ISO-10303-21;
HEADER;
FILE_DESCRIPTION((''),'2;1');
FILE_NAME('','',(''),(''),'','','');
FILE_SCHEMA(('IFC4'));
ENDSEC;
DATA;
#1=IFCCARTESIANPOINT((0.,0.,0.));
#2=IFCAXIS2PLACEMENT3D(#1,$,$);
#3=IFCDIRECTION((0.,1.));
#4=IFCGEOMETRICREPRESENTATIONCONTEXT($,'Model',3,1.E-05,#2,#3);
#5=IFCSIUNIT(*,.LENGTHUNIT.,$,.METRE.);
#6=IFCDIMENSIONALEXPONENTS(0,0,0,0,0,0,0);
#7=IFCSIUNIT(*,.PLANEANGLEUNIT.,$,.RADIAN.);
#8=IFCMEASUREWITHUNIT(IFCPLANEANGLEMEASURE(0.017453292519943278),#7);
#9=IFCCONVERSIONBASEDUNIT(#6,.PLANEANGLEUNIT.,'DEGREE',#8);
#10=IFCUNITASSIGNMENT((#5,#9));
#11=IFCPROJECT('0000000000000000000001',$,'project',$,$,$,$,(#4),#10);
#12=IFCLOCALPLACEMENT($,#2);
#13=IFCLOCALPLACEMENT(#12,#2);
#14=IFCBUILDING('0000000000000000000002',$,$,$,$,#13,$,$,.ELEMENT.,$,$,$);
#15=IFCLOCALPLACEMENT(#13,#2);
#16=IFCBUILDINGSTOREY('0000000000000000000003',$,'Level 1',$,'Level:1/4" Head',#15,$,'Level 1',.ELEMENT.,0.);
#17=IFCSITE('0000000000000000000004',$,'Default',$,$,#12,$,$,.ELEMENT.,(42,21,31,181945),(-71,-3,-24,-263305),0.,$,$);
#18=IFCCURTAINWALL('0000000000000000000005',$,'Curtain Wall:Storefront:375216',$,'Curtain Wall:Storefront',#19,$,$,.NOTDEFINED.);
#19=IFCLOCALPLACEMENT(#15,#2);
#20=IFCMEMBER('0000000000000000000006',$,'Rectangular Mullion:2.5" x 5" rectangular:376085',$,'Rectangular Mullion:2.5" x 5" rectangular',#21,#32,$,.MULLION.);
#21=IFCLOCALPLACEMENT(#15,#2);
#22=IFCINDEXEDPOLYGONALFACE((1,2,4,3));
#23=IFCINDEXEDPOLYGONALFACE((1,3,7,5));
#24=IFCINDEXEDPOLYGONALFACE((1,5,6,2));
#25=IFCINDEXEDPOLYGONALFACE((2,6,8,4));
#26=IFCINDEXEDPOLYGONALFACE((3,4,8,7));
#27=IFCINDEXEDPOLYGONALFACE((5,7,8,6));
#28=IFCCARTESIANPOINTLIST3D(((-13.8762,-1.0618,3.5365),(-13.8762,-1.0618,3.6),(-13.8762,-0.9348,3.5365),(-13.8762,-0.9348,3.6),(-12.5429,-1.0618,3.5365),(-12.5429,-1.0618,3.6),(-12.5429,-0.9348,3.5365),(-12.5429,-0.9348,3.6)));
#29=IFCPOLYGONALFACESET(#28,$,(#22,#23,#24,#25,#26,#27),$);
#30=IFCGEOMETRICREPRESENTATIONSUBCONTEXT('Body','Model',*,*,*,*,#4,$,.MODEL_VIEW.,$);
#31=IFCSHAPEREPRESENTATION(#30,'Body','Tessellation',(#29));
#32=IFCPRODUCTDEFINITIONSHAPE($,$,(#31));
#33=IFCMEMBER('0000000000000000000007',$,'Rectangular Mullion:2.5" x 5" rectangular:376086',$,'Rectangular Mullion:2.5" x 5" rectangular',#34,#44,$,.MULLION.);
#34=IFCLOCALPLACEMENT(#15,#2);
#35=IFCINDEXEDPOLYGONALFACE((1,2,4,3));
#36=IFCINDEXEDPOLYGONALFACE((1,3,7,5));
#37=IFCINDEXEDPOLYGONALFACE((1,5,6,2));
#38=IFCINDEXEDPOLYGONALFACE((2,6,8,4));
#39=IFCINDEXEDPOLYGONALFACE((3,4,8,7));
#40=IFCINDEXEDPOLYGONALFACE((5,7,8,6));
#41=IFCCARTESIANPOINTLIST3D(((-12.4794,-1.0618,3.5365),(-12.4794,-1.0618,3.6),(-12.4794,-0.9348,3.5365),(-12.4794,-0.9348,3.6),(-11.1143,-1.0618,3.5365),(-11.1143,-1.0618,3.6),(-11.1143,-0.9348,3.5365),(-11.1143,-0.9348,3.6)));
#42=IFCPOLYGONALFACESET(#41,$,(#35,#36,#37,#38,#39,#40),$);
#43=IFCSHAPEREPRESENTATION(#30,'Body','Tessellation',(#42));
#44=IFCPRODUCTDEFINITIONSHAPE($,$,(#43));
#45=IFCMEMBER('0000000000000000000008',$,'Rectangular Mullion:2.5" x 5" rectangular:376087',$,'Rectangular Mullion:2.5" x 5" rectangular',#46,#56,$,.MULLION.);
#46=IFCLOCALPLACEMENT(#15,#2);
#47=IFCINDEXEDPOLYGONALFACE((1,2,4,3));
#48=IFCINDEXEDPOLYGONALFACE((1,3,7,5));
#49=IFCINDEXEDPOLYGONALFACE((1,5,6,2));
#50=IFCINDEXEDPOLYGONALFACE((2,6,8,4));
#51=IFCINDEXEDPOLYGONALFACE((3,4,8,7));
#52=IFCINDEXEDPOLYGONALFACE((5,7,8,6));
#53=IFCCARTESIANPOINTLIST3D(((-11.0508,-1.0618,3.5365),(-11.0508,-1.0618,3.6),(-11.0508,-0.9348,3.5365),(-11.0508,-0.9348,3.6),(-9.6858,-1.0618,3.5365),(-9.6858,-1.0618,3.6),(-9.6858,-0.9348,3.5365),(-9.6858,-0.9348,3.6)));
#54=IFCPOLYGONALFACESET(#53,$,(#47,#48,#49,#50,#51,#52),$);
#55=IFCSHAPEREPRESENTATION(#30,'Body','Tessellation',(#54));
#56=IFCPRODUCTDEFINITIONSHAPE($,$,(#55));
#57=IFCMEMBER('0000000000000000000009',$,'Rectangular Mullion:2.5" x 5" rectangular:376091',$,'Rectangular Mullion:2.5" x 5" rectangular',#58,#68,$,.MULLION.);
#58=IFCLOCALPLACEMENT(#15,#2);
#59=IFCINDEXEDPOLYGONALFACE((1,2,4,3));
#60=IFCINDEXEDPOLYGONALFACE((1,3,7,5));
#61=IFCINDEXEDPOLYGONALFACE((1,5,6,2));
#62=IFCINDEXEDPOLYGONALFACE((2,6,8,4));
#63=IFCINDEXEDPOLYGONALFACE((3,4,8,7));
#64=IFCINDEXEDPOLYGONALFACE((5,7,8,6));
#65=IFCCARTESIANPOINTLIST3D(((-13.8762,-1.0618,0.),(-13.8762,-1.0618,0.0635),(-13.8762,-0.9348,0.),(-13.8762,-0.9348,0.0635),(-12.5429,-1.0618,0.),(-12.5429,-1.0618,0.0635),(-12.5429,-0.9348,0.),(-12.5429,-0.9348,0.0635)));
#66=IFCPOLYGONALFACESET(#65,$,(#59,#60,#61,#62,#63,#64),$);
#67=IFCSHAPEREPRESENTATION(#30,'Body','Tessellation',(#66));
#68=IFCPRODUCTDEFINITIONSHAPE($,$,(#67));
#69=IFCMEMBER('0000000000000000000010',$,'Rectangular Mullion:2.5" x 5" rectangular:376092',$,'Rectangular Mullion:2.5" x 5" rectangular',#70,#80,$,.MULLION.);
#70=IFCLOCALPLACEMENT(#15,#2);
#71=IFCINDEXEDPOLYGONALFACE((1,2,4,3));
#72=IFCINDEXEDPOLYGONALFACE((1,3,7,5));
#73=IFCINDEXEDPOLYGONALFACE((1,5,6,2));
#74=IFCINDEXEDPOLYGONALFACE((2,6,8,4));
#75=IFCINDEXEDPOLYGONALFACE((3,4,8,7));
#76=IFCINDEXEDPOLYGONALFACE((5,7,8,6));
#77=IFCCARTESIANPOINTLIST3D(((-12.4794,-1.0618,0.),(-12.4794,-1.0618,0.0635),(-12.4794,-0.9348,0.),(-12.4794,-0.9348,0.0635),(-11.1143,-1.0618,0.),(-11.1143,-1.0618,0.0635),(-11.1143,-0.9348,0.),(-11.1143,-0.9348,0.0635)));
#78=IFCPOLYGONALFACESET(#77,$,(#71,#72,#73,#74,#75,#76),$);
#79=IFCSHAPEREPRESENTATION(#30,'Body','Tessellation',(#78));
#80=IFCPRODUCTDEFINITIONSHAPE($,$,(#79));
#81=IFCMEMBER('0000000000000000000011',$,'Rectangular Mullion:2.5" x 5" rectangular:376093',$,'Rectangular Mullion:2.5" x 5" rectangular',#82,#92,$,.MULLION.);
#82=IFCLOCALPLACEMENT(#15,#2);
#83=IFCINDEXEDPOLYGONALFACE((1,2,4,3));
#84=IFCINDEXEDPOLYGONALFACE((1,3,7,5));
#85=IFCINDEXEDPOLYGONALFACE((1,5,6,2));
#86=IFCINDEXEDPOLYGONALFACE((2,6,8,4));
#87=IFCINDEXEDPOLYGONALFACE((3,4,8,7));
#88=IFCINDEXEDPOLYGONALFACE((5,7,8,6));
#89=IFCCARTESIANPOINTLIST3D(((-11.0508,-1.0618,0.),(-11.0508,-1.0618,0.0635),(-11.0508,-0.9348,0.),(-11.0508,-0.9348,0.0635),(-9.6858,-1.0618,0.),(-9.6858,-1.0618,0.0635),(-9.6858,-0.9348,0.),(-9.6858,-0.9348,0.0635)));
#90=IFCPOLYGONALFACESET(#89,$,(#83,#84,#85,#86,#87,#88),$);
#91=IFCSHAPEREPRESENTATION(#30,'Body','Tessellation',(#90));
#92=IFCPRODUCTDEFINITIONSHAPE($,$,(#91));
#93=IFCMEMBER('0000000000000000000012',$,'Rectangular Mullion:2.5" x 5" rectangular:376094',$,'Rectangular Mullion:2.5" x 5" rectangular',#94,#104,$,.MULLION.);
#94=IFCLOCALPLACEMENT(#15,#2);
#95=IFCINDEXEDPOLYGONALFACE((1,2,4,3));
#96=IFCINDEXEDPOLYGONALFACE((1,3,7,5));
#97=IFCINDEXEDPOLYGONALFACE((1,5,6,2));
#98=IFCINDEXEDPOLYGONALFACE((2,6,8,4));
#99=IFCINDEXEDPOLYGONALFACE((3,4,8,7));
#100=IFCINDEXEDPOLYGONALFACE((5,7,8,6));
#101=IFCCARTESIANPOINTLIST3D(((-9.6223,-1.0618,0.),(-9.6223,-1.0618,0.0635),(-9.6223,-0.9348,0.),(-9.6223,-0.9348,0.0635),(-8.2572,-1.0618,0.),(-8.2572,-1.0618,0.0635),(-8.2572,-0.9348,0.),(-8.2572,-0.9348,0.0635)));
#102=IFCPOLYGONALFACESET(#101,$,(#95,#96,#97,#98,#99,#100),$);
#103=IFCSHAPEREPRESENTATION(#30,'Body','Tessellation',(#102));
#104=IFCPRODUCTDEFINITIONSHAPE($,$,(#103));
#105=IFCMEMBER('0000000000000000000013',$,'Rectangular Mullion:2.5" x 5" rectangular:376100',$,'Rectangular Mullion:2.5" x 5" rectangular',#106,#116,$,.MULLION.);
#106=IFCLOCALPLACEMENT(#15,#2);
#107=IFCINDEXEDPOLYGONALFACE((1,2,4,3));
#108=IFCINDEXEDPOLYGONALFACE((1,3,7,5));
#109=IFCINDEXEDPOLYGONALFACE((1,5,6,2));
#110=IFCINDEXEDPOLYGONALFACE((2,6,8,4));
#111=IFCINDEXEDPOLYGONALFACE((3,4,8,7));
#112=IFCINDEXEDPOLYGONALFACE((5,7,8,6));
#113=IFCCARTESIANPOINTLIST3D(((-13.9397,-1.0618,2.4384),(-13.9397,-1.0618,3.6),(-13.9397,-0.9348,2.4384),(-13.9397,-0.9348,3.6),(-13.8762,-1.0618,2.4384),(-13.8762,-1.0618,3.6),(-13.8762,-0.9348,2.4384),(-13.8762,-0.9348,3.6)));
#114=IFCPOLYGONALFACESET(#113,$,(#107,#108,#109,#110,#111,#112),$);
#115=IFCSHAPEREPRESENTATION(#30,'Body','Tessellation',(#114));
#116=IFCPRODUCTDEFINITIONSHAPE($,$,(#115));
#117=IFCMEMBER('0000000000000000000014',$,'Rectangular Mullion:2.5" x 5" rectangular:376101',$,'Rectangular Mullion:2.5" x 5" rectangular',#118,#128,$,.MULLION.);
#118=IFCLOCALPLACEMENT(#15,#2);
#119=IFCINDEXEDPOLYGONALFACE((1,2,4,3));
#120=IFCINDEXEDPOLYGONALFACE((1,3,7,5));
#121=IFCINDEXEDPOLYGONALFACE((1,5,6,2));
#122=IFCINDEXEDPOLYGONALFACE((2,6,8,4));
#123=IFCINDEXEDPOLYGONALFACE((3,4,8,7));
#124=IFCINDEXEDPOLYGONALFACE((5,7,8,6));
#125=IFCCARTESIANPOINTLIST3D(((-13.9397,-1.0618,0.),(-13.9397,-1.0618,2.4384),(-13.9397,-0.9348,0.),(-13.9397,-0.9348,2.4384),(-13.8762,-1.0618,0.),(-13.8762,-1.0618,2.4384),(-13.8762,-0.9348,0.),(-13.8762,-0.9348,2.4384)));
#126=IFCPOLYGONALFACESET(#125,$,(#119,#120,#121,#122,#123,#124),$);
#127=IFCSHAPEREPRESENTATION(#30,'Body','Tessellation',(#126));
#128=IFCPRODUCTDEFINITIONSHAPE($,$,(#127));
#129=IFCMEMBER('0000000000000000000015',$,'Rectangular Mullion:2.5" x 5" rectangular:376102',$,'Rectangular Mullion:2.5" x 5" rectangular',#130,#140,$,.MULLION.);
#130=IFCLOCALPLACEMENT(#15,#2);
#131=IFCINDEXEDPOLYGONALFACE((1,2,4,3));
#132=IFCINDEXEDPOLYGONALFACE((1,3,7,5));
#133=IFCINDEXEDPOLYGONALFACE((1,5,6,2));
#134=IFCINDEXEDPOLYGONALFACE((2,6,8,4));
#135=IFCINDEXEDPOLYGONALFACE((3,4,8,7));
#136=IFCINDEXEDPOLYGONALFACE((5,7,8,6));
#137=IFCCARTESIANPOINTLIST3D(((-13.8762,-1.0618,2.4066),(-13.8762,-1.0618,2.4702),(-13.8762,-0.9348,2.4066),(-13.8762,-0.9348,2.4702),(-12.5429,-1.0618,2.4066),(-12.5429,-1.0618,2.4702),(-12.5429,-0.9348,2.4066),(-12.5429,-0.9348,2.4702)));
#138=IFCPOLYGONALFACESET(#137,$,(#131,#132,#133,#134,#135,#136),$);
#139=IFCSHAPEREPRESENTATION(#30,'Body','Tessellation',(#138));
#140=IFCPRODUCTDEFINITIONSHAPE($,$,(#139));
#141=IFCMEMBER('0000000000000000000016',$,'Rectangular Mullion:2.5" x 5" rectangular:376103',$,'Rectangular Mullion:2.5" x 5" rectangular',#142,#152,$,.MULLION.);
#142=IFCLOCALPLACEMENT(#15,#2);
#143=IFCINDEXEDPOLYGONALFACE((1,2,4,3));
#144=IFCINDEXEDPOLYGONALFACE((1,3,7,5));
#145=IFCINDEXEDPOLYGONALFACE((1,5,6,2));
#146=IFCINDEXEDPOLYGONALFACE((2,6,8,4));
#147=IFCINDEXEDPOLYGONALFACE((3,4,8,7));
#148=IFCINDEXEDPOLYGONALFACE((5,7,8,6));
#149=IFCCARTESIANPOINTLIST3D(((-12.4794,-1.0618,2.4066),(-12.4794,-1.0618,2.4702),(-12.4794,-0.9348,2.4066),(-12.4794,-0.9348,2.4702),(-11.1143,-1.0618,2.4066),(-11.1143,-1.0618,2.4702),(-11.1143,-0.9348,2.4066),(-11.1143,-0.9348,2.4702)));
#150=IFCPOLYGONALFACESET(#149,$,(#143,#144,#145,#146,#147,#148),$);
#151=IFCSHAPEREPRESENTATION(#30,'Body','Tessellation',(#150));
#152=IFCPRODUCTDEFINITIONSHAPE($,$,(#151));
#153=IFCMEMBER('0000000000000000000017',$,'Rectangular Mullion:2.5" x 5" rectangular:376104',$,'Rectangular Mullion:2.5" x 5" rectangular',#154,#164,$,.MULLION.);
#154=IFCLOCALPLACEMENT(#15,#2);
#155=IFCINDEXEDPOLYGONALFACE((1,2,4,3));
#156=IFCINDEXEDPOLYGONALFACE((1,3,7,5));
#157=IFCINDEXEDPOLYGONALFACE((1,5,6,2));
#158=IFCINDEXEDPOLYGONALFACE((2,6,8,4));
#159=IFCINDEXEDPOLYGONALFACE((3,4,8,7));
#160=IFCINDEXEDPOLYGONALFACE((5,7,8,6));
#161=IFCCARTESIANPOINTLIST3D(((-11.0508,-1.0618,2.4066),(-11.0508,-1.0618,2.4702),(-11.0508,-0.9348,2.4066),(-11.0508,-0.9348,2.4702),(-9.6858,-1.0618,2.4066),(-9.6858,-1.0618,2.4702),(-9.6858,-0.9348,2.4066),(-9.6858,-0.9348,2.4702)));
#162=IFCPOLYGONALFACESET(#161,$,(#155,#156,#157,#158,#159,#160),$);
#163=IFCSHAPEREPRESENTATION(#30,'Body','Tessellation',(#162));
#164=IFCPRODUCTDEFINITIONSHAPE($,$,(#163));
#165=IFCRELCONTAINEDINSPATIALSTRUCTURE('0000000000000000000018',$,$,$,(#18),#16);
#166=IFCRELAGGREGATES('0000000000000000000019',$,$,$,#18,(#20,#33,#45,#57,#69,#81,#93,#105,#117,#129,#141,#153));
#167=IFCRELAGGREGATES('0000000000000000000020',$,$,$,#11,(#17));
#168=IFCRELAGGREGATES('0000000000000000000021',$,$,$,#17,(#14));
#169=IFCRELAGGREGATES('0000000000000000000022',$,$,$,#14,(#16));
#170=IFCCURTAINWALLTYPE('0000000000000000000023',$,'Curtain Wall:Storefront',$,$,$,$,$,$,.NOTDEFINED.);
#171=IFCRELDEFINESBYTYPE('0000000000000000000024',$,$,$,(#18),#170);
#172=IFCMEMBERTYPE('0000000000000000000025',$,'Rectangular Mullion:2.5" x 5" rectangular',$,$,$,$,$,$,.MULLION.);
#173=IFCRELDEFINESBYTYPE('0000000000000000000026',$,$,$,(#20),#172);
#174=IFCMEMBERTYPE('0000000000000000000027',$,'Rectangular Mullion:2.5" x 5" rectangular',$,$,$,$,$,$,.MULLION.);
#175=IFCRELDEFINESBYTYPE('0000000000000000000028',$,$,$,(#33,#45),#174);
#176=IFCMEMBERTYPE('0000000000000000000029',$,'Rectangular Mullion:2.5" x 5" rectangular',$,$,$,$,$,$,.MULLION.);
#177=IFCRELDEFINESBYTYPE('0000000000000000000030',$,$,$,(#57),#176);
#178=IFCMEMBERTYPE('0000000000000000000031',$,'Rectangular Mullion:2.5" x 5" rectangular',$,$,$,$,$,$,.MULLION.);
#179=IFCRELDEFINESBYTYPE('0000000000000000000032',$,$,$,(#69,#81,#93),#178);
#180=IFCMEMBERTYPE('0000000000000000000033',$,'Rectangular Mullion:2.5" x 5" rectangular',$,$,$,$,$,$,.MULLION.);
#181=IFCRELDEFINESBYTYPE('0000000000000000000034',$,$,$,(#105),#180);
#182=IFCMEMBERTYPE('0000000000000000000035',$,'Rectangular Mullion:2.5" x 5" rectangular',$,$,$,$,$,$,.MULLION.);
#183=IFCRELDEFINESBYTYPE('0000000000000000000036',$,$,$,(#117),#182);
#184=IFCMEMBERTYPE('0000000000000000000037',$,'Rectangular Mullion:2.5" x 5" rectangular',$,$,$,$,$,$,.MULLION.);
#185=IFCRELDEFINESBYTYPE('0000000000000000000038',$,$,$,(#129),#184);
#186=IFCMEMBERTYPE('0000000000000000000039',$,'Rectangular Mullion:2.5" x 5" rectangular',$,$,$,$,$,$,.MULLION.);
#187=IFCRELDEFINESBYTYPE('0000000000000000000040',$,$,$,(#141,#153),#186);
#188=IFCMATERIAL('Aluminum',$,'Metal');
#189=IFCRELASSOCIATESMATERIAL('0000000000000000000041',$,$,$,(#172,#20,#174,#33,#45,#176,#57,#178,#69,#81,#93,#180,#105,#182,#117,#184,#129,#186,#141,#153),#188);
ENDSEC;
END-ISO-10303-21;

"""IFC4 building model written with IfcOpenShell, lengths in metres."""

from ifc_helpers import new_model, entity, si_unit, converted_unit, direction, frame, origin, place, context, subcontext, project, spatial, indexed_curve, outline, extrude, source, transform, mapped, material, type_object, type_shapes, element, aggregate, save


model = new_model("IFC4")

# Units and contexts
model_context = context("Model", 3, precision=1e-05, world=origin(), true_north=direction((0.0, 1.0)))
body_context = subcontext(model_context, "Body", "Model", "MODEL_VIEW")
ifc_project = project(units=[si_unit("LENGTHUNIT", "METRE"), converted_unit("PLANEANGLEUNIT", "DEGREE", entity("IfcPlaneAngleMeasure", 0.017453292519943278), si_unit("PLANEANGLEUNIT", "RADIAN"), dimensions=[0, 0, 0, 0, 0, 0, 0])], contexts=[model_context])

# Site, building, storey
site_placement = place(None, origin())
site = spatial("IfcSite", under=ifc_project, at=site_placement, Name="Default", CompositionType="ELEMENT", RefLatitude=(42, 21, 31, 181945), RefLongitude=(-71, -3, -24, -263305), RefElevation=0.0)
building_placement = place(site_placement, origin())
building = spatial("IfcBuilding", under=site, at=building_placement, CompositionType="ELEMENT")
storey_placement = place(building_placement, origin())
storey = spatial("IfcBuildingStorey", under=building, at=storey_placement, Name="Level 1", ObjectType="Level:1/4\" Head", LongName="Level 1", CompositionType="ELEMENT", Elevation=0.0)

# Curtain wall, members
curtain_wall_type = type_object("IfcCurtainWallType", Name="Curtain Wall:Storefront", PredefinedType="NOTDEFINED")
curtain_wall_placement = place(storey_placement, origin())
curtain_wall = element("IfcCurtainWall", 1, at=curtain_wall_placement, inside=storey, type_object=curtain_wall_type, Name="Curtain Wall:Storefront:375216", ObjectType="Curtain Wall:Storefront", PredefinedType="NOTDEFINED")
ifc_material_1 = material(Name="Aluminum", Category="Metal")
member_type_1 = type_object("IfcMemberType", Name="Rectangular Mullion:2.5\" x 5\" rectangular", PredefinedType="MULLION", material=ifc_material_1)
shared_shape_1 = source(origin(), body_context, "Body", "SweptSolid", [
    extrude(outline(indexed_curve([(-0.0318, -0.0635), (0.0318, -0.0635), (0.0318, 0.0635), (-0.0318, 0.0635), (-0.0318, -0.0635)], self_intersect=False)), frame((-0.0318, 0.0, -1.3333), z_axis=(0.0, 0.0, 1.0), x_axis=(-1.0, 0.0, 0.0)), (0.0, 0.0, 1.0), 1.3333),
])
type_shapes(member_type_1, [shared_shape_1])
member_1_placement = place(curtain_wall_placement, frame((-12.5429, -0.9983, 3.6), z_axis=(1.0, 0.0, 0.0), x_axis=(0.0, 0.0, 1.0)))
member_1 = element("IfcMember", 2, at=member_1_placement, type_object=member_type_1, material=ifc_material_1, Name="Rectangular Mullion:2.5\" x 5\" rectangular:376085", ObjectType="Rectangular Mullion:2.5\" x 5\" rectangular", PredefinedType="MULLION", context=body_context, shape_type="MappedRepresentation", body=[
    mapped(shared_shape_1, transform((0.0, 0.0, 0.0), scale=1.0)),
])
member_type_2 = type_object("IfcMemberType", Name="Rectangular Mullion:2.5\" x 5\" rectangular", PredefinedType="MULLION", material=ifc_material_1)
shared_shape_2 = source(origin(), body_context, "Body", "SweptSolid", [
    extrude(outline(indexed_curve([(-0.0318, -0.0635), (0.0318, -0.0635), (0.0318, 0.0635), (-0.0318, 0.0635), (-0.0318, -0.0635)], self_intersect=False)), frame((-0.0318, 0.0, -1.3651), z_axis=(0.0, 0.0, 1.0), x_axis=(-1.0, 0.0, 0.0)), (0.0, 0.0, 1.0), 1.3651),
])
type_shapes(member_type_2, [shared_shape_2])
member_2_placement = place(curtain_wall_placement, frame((-11.1143, -0.9983, 3.6), z_axis=(1.0, 0.0, 0.0), x_axis=(0.0, 0.0, 1.0)))
member_2 = element("IfcMember", 3, at=member_2_placement, type_object=member_type_2, material=ifc_material_1, Name="Rectangular Mullion:2.5\" x 5\" rectangular:376086", ObjectType="Rectangular Mullion:2.5\" x 5\" rectangular", PredefinedType="MULLION", context=body_context, shape_type="MappedRepresentation", body=[
    mapped(shared_shape_2, transform((0.0, 0.0, 0.0), scale=1.0)),
])
member_3_placement = place(curtain_wall_placement, frame((-9.6858, -0.9983, 3.6), z_axis=(1.0, 0.0, 0.0), x_axis=(0.0, 0.0, 1.0)))
member_3 = element("IfcMember", 4, at=member_3_placement, type_object=member_type_2, material=ifc_material_1, Name="Rectangular Mullion:2.5\" x 5\" rectangular:376087", ObjectType="Rectangular Mullion:2.5\" x 5\" rectangular", PredefinedType="MULLION", context=body_context, shape_type="MappedRepresentation", body=[
    mapped(shared_shape_2, transform((0.0, 0.0, 0.0), scale=1.0)),
])
member_type_3 = type_object("IfcMemberType", Name="Rectangular Mullion:2.5\" x 5\" rectangular", PredefinedType="MULLION", material=ifc_material_1)
shared_shape_3 = source(origin(), body_context, "Body", "SweptSolid", [
    extrude(outline(indexed_curve([(-0.0318, -0.0635), (0.0318, -0.0635), (0.0318, 0.0635), (-0.0318, 0.0635), (-0.0318, -0.0635)], self_intersect=False)), frame((-0.0318, 0.0, -1.3333), z_axis=(0.0, 0.0, 1.0), x_axis=(-1.0, 0.0, 0.0)), (0.0, 0.0, 1.0), 1.3333),
])
type_shapes(member_type_3, [shared_shape_3])
member_4_placement = place(curtain_wall_placement, frame((-13.8762, -0.9983, 0.0), z_axis=(-1.0, 0.0, 0.0), x_axis=(0.0, 0.0, -1.0)))
member_4 = element("IfcMember", 5, at=member_4_placement, type_object=member_type_3, material=ifc_material_1, Name="Rectangular Mullion:2.5\" x 5\" rectangular:376091", ObjectType="Rectangular Mullion:2.5\" x 5\" rectangular", PredefinedType="MULLION", context=body_context, shape_type="MappedRepresentation", body=[
    mapped(shared_shape_3, transform((0.0, 0.0, 0.0), scale=1.0)),
])
member_type_4 = type_object("IfcMemberType", Name="Rectangular Mullion:2.5\" x 5\" rectangular", PredefinedType="MULLION", material=ifc_material_1)
shared_shape_4 = source(origin(), body_context, "Body", "SweptSolid", [
    extrude(outline(indexed_curve([(-0.0318, -0.0635), (0.0318, -0.0635), (0.0318, 0.0635), (-0.0318, 0.0635), (-0.0318, -0.0635)], self_intersect=False)), frame((-0.0318, 0.0, -1.3651), z_axis=(0.0, 0.0, 1.0), x_axis=(-1.0, 0.0, 0.0)), (0.0, 0.0, 1.0), 1.3651),
])
type_shapes(member_type_4, [shared_shape_4])
member_5_placement = place(curtain_wall_placement, frame((-12.4794, -0.9983, 0.0), z_axis=(-1.0, 0.0, 0.0), x_axis=(0.0, 0.0, -1.0)))
member_5 = element("IfcMember", 6, at=member_5_placement, type_object=member_type_4, material=ifc_material_1, Name="Rectangular Mullion:2.5\" x 5\" rectangular:376092", ObjectType="Rectangular Mullion:2.5\" x 5\" rectangular", PredefinedType="MULLION", context=body_context, shape_type="MappedRepresentation", body=[
    mapped(shared_shape_4, transform((0.0, 0.0, 0.0), scale=1.0)),
])
member_6_placement = place(curtain_wall_placement, frame((-11.0508, -0.9983, 0.0), z_axis=(-1.0, 0.0, 0.0), x_axis=(0.0, 0.0, -1.0)))
member_6 = element("IfcMember", 7, at=member_6_placement, type_object=member_type_4, material=ifc_material_1, Name="Rectangular Mullion:2.5\" x 5\" rectangular:376093", ObjectType="Rectangular Mullion:2.5\" x 5\" rectangular", PredefinedType="MULLION", context=body_context, shape_type="MappedRepresentation", body=[
    mapped(shared_shape_4, transform((0.0, 0.0, 0.0), scale=1.0)),
])
member_7_placement = place(curtain_wall_placement, frame((-9.6223, -0.9983, 0.0), z_axis=(-1.0, 0.0, 0.0), x_axis=(0.0, 0.0, -1.0)))
member_7 = element("IfcMember", 8, at=member_7_placement, type_object=member_type_4, material=ifc_material_1, Name="Rectangular Mullion:2.5\" x 5\" rectangular:376094", ObjectType="Rectangular Mullion:2.5\" x 5\" rectangular", PredefinedType="MULLION", context=body_context, shape_type="MappedRepresentation", body=[
    mapped(shared_shape_4, transform((0.0, 0.0, 0.0), scale=1.0)),
])
member_type_5 = type_object("IfcMemberType", Name="Rectangular Mullion:2.5\" x 5\" rectangular", PredefinedType="MULLION", material=ifc_material_1)
shared_shape_5 = source(origin(), body_context, "Body", "SweptSolid", [
    extrude(outline(indexed_curve([(-0.0318, -0.0635), (0.0318, -0.0635), (0.0318, 0.0635), (-0.0318, 0.0635), (-0.0318, -0.0635)], self_intersect=False)), frame((-0.0318, 0.0, -1.1616), z_axis=(0.0, 0.0, 1.0), x_axis=(-1.0, 0.0, 0.0)), (0.0, 0.0, 1.0), 1.1616),
])
type_shapes(member_type_5, [shared_shape_5])
member_8_placement = place(curtain_wall_placement, frame((-13.9397, -0.9983, 3.6), z_axis=(0.0, 0.0, 1.0), x_axis=(-1.0, 0.0, 0.0)))
member_8 = element("IfcMember", 9, at=member_8_placement, type_object=member_type_5, material=ifc_material_1, Name="Rectangular Mullion:2.5\" x 5\" rectangular:376100", ObjectType="Rectangular Mullion:2.5\" x 5\" rectangular", PredefinedType="MULLION", context=body_context, shape_type="MappedRepresentation", body=[
    mapped(shared_shape_5, transform((0.0, 0.0, 0.0), scale=1.0)),
])
member_type_6 = type_object("IfcMemberType", Name="Rectangular Mullion:2.5\" x 5\" rectangular", PredefinedType="MULLION", material=ifc_material_1)
shared_shape_6 = source(origin(), body_context, "Body", "SweptSolid", [
    extrude(outline(indexed_curve([(-0.0318, -0.0635), (0.0318, -0.0635), (0.0318, 0.0635), (-0.0318, 0.0635), (-0.0318, -0.0635)], self_intersect=False)), frame((-0.0318, 0.0, -2.4384), z_axis=(0.0, 0.0, 1.0), x_axis=(-1.0, 0.0, 0.0)), (0.0, 0.0, 1.0), 2.4384),
])
type_shapes(member_type_6, [shared_shape_6])
member_9_placement = place(curtain_wall_placement, frame((-13.9397, -0.9983, 2.4384), z_axis=(0.0, 0.0, 1.0), x_axis=(-1.0, 0.0, 0.0)))
member_9 = element("IfcMember", 10, at=member_9_placement, type_object=member_type_6, material=ifc_material_1, Name="Rectangular Mullion:2.5\" x 5\" rectangular:376101", ObjectType="Rectangular Mullion:2.5\" x 5\" rectangular", PredefinedType="MULLION", context=body_context, shape_type="MappedRepresentation", body=[
    mapped(shared_shape_6, transform((0.0, 0.0, 0.0), scale=1.0)),
])
member_type_7 = type_object("IfcMemberType", Name="Rectangular Mullion:2.5\" x 5\" rectangular", PredefinedType="MULLION", material=ifc_material_1)
shared_shape_7 = source(origin(), body_context, "Body", "SweptSolid", [
    extrude(outline(indexed_curve([(-0.0318, -0.0635), (0.0318, -0.0635), (0.0318, 0.0635), (-0.0318, 0.0635), (-0.0318, -0.0635)], self_intersect=False)), frame((0.0, 0.0, -1.3333), z_axis=(0.0, 0.0, 1.0), x_axis=(-1.0, 0.0, 0.0)), (0.0, 0.0, 1.0), 1.3333),
])
type_shapes(member_type_7, [shared_shape_7])
member_10_placement = place(curtain_wall_placement, frame((-12.5429, -0.9983, 2.4384), z_axis=(1.0, 0.0, 0.0), x_axis=(0.0, 0.0, 1.0)))
member_10 = element("IfcMember", 11, at=member_10_placement, type_object=member_type_7, material=ifc_material_1, Name="Rectangular Mullion:2.5\" x 5\" rectangular:376102", ObjectType="Rectangular Mullion:2.5\" x 5\" rectangular", PredefinedType="MULLION", context=body_context, shape_type="MappedRepresentation", body=[
    mapped(shared_shape_7, transform((0.0, 0.0, 0.0), scale=1.0)),
])
member_type_8 = type_object("IfcMemberType", Name="Rectangular Mullion:2.5\" x 5\" rectangular", PredefinedType="MULLION", material=ifc_material_1)
shared_shape_8 = source(origin(), body_context, "Body", "SweptSolid", [
    extrude(outline(indexed_curve([(-0.0318, -0.0635), (0.0318, -0.0635), (0.0318, 0.0635), (-0.0318, 0.0635), (-0.0318, -0.0635)], self_intersect=False)), frame((0.0, 0.0, -1.3651), z_axis=(0.0, 0.0, 1.0), x_axis=(-1.0, 0.0, 0.0)), (0.0, 0.0, 1.0), 1.3651),
])
type_shapes(member_type_8, [shared_shape_8])
member_11_placement = place(curtain_wall_placement, frame((-11.1143, -0.9983, 2.4384), z_axis=(1.0, 0.0, 0.0), x_axis=(0.0, 0.0, 1.0)))
member_11 = element("IfcMember", 12, at=member_11_placement, type_object=member_type_8, material=ifc_material_1, Name="Rectangular Mullion:2.5\" x 5\" rectangular:376103", ObjectType="Rectangular Mullion:2.5\" x 5\" rectangular", PredefinedType="MULLION", context=body_context, shape_type="MappedRepresentation", body=[
    mapped(shared_shape_8, transform((0.0, 0.0, 0.0), scale=1.0)),
])
member_12_placement = place(curtain_wall_placement, frame((-9.6858, -0.9983, 2.4384), z_axis=(1.0, 0.0, 0.0), x_axis=(0.0, 0.0, 1.0)))
member_12 = element("IfcMember", 13, at=member_12_placement, type_object=member_type_8, material=ifc_material_1, Name="Rectangular Mullion:2.5\" x 5\" rectangular:376104", ObjectType="Rectangular Mullion:2.5\" x 5\" rectangular", PredefinedType="MULLION", context=body_context, shape_type="MappedRepresentation", body=[
    mapped(shared_shape_8, transform((0.0, 0.0, 0.0), scale=1.0)),
])
aggregate(curtain_wall, [member_1, member_2, member_3, member_4, member_5, member_6, member_7, member_8, member_9, member_10, member_11, member_12])

save(model, "model.ifc")
